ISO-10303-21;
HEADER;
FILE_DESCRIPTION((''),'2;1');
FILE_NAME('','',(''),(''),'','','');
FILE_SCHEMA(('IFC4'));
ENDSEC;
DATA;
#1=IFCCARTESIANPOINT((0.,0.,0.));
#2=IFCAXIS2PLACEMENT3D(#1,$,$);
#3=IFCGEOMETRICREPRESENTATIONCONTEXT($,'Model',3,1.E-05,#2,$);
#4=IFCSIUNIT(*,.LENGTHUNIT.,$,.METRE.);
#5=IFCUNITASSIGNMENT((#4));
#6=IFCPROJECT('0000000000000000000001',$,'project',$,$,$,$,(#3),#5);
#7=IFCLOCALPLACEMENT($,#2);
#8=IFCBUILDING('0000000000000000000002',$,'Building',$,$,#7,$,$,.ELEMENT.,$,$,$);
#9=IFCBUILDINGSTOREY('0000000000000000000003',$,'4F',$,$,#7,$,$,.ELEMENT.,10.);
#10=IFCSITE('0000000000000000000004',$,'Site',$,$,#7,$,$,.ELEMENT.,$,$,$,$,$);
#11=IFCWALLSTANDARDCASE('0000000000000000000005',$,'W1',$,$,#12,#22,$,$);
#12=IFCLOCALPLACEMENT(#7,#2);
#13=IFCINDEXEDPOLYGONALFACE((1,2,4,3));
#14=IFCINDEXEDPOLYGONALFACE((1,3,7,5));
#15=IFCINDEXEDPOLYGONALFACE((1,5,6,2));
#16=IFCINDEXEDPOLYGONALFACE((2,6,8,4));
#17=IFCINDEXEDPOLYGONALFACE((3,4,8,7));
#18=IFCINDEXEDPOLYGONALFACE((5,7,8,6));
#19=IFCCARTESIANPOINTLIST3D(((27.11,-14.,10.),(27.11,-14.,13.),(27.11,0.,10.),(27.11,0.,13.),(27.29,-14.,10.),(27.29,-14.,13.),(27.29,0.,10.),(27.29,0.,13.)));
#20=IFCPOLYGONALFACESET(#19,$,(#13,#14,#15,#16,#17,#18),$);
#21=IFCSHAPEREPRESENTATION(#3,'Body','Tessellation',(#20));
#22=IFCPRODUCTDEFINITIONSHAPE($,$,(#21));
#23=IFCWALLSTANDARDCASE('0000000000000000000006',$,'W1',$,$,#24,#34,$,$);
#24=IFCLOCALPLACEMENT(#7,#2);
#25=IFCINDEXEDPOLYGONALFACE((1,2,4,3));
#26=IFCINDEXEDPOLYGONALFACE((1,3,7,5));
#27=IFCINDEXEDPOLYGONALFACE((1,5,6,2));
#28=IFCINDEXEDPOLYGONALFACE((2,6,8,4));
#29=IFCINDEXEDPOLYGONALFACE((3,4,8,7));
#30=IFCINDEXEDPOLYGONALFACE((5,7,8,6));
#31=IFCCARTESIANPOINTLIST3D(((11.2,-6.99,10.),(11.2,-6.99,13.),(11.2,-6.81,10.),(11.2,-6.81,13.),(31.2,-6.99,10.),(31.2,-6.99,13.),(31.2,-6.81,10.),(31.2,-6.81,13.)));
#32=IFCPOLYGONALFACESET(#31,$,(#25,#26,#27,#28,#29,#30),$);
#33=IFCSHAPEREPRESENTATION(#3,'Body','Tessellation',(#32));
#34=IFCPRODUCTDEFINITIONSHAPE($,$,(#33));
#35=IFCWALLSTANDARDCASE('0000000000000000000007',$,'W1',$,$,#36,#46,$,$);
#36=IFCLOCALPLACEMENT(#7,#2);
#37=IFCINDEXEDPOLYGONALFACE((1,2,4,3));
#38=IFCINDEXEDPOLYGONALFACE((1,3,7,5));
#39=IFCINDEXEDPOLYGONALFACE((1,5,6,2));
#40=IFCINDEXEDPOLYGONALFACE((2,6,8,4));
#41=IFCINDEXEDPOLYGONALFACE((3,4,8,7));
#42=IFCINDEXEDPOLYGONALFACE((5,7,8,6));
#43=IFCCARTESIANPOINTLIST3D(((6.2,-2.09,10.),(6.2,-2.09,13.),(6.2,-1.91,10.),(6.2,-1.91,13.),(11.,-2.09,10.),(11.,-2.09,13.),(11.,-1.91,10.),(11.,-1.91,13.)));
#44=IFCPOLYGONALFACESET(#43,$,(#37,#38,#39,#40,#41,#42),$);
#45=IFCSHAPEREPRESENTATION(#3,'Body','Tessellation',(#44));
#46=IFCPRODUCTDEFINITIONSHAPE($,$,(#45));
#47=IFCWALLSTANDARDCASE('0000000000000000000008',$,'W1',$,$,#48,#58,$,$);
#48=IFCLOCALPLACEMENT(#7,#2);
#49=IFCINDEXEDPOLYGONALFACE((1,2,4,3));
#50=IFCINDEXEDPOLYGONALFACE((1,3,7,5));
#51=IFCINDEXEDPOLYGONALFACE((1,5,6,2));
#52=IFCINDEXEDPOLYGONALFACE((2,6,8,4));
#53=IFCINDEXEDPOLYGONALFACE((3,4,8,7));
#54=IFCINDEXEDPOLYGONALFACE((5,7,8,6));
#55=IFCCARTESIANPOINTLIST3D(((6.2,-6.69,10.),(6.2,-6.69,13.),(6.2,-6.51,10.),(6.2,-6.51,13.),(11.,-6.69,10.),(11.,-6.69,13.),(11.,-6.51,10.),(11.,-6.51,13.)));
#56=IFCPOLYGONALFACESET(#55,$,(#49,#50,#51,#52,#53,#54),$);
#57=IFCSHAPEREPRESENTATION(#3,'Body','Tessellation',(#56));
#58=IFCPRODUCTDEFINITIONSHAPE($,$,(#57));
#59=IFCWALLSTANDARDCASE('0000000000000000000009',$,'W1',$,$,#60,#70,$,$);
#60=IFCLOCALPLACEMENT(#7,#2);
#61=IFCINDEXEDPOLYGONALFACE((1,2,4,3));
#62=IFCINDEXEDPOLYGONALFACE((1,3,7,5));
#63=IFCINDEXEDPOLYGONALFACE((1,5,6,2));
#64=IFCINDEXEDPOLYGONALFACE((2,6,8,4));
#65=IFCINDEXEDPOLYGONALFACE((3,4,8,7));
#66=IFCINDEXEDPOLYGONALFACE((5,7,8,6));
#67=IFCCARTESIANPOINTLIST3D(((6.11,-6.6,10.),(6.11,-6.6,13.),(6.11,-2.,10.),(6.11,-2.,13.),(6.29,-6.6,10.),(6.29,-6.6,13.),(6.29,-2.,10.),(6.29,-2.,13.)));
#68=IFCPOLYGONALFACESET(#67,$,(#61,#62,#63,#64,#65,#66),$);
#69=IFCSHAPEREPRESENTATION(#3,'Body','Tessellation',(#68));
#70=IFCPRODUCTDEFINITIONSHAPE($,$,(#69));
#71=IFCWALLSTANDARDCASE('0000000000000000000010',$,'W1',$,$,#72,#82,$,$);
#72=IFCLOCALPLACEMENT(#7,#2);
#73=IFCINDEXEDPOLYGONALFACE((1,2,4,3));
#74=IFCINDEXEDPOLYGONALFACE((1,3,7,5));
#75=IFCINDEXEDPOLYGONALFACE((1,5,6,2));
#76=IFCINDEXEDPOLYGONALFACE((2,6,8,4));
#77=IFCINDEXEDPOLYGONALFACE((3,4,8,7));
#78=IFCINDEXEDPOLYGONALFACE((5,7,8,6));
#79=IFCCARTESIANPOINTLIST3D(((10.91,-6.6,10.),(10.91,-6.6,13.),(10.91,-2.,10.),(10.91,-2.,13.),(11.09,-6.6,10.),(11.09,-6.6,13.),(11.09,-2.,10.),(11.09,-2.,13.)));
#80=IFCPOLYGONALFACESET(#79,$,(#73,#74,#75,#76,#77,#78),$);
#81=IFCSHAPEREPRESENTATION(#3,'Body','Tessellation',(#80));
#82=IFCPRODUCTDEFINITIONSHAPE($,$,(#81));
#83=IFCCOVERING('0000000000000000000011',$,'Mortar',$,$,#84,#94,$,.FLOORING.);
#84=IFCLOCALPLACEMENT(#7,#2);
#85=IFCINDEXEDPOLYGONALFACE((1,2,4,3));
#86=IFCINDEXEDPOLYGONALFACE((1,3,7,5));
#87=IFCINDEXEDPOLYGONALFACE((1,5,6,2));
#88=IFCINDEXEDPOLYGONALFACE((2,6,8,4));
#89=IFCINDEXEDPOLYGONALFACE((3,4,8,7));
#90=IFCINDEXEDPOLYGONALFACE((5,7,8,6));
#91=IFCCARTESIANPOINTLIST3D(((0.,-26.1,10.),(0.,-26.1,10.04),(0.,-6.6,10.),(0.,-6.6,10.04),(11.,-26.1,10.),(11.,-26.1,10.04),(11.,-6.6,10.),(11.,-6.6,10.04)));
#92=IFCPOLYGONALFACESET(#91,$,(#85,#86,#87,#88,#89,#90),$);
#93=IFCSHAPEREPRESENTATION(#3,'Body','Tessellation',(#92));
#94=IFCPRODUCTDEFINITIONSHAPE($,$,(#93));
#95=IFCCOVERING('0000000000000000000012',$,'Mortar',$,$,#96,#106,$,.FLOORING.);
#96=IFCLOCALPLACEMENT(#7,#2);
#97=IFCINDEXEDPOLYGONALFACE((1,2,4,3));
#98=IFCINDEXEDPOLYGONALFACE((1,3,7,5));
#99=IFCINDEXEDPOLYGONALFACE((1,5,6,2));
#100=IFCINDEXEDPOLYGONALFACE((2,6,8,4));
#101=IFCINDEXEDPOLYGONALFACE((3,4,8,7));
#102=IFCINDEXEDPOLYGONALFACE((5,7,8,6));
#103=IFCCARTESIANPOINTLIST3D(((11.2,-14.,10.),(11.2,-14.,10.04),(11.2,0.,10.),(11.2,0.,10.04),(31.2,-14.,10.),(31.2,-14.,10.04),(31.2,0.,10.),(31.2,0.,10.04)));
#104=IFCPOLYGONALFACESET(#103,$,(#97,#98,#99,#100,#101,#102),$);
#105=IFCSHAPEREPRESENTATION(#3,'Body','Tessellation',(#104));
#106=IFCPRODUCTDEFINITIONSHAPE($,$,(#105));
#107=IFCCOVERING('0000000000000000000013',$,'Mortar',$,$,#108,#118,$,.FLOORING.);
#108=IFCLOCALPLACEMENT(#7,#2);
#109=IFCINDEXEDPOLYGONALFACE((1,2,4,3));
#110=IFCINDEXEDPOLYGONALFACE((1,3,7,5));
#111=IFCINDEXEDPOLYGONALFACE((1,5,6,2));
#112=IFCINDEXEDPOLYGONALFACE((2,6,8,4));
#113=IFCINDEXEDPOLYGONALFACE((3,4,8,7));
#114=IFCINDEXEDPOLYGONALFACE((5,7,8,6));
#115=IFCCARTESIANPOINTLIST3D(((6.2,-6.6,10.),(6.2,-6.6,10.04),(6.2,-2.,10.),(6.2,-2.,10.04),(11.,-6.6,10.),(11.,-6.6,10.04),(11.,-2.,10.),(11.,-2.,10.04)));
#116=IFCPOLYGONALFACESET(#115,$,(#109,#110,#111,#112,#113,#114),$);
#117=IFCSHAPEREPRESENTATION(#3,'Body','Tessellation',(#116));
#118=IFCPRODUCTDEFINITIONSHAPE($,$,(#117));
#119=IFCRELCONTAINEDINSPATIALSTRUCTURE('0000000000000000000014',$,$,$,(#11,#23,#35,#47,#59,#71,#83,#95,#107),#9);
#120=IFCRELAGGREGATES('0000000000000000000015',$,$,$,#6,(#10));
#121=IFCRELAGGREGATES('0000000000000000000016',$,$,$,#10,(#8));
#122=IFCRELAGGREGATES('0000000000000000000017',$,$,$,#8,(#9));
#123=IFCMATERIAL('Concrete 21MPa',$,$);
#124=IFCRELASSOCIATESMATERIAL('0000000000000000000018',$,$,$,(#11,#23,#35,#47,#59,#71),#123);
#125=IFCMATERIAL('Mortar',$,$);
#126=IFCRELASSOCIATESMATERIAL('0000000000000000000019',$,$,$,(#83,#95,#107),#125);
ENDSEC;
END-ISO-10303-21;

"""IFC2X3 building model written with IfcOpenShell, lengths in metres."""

from ifc_helpers import new_model, si_unit, frame, origin, origin_2d, place, context, project, spatial, rectangle, extrude, material, element, save


model = new_model("IFC2X3")

# Units and contexts
model_context = context("Model", 3, precision=1e-05, world=origin())
ifc_project = project(units=[si_unit("LENGTHUNIT", "METRE")], contexts=[model_context])

# Site, building, storey
placement = place(None, origin())
site = spatial("IfcSite", under=ifc_project, at=placement, Name="Site", CompositionType="ELEMENT")
building = spatial("IfcBuilding", under=site, at=placement, Name="Building", CompositionType="ELEMENT")
storey = spatial("IfcBuildingStorey", under=building, at=placement, Name="4F", CompositionType="ELEMENT", Elevation=10.0)

# Shared definitions
ifc_material_1 = material(Name="Concrete 21MPa")

# Walls
for number, where, name in (
    (1, (27.2, -7.0, 10.0), "W1"),
):
    element("IfcWallStandardCase", number, at=place(None, frame(where)), inside=storey, material=ifc_material_1, Name=name, context=model_context, shape_type="SweptSolid", body=[
        extrude(rectangle(XDim=0.18, YDim=14.0, at=origin_2d()), origin(), (0.0, 0.0, 1.0), 3.0),
    ])
wall_1_placement = place(None, frame((21.2, -6.9, 10.0)))
element("IfcWallStandardCase", 2, at=wall_1_placement, inside=storey, material=ifc_material_1, Name="W1", context=model_context, shape_type="SweptSolid", body=[
    extrude(rectangle(XDim=20.0, YDim=0.18, at=origin_2d()), origin(), (0.0, 0.0, 1.0), 3.0),
])
for number, where, name in (
    (3, (8.6, -2.0, 10.0), "W1"),
    (4, (8.6, -6.6, 10.0), "W1"),
):
    element("IfcWallStandardCase", number, at=place(None, frame(where)), inside=storey, material=ifc_material_1, Name=name, context=model_context, shape_type="SweptSolid", body=[
        extrude(rectangle(XDim=4.8, YDim=0.18, at=origin_2d()), origin(), (0.0, 0.0, 1.0), 3.0),
    ])
for number, where, name in (
    (5, (6.2, -4.3, 10.0), "W1"),
    (6, (11.0, -4.3, 10.0), "W1"),
):
    element("IfcWallStandardCase", number, at=place(None, frame(where)), inside=storey, material=ifc_material_1, Name=name, context=model_context, shape_type="SweptSolid", body=[
        extrude(rectangle(XDim=0.18, YDim=4.6, at=origin_2d()), origin(), (0.0, 0.0, 1.0), 3.0),
    ])

# Coverings
ifc_material_2 = material(Name="Mortar")
covering_1_placement = place(None, frame((5.5, -16.35, 10.0)))
element("IfcCovering", 7, at=covering_1_placement, inside=storey, material=ifc_material_2, Name="Mortar", PredefinedType="FLOORING", context=model_context, shape_type="SweptSolid", body=[
    extrude(rectangle(XDim=11.0, YDim=19.5, at=origin_2d()), origin(), (0.0, 0.0, 1.0), 0.04),
])
covering_2_placement = place(None, frame((21.2, -7.0, 10.0)))
element("IfcCovering", 8, at=covering_2_placement, inside=storey, material=ifc_material_2, Name="Mortar", PredefinedType="FLOORING", context=model_context, shape_type="SweptSolid", body=[
    extrude(rectangle(XDim=20.0, YDim=14.0, at=origin_2d()), origin(), (0.0, 0.0, 1.0), 0.04),
])
covering_3_placement = place(None, frame((8.6, -4.3, 10.0)))
element("IfcCovering", 9, at=covering_3_placement, inside=storey, material=ifc_material_2, Name="Mortar", PredefinedType="FLOORING", context=model_context, shape_type="SweptSolid", body=[
    extrude(rectangle(XDim=4.8, YDim=4.6, at=origin_2d()), origin(), (0.0, 0.0, 1.0), 0.04),
])

save(model, "model.ifc")
